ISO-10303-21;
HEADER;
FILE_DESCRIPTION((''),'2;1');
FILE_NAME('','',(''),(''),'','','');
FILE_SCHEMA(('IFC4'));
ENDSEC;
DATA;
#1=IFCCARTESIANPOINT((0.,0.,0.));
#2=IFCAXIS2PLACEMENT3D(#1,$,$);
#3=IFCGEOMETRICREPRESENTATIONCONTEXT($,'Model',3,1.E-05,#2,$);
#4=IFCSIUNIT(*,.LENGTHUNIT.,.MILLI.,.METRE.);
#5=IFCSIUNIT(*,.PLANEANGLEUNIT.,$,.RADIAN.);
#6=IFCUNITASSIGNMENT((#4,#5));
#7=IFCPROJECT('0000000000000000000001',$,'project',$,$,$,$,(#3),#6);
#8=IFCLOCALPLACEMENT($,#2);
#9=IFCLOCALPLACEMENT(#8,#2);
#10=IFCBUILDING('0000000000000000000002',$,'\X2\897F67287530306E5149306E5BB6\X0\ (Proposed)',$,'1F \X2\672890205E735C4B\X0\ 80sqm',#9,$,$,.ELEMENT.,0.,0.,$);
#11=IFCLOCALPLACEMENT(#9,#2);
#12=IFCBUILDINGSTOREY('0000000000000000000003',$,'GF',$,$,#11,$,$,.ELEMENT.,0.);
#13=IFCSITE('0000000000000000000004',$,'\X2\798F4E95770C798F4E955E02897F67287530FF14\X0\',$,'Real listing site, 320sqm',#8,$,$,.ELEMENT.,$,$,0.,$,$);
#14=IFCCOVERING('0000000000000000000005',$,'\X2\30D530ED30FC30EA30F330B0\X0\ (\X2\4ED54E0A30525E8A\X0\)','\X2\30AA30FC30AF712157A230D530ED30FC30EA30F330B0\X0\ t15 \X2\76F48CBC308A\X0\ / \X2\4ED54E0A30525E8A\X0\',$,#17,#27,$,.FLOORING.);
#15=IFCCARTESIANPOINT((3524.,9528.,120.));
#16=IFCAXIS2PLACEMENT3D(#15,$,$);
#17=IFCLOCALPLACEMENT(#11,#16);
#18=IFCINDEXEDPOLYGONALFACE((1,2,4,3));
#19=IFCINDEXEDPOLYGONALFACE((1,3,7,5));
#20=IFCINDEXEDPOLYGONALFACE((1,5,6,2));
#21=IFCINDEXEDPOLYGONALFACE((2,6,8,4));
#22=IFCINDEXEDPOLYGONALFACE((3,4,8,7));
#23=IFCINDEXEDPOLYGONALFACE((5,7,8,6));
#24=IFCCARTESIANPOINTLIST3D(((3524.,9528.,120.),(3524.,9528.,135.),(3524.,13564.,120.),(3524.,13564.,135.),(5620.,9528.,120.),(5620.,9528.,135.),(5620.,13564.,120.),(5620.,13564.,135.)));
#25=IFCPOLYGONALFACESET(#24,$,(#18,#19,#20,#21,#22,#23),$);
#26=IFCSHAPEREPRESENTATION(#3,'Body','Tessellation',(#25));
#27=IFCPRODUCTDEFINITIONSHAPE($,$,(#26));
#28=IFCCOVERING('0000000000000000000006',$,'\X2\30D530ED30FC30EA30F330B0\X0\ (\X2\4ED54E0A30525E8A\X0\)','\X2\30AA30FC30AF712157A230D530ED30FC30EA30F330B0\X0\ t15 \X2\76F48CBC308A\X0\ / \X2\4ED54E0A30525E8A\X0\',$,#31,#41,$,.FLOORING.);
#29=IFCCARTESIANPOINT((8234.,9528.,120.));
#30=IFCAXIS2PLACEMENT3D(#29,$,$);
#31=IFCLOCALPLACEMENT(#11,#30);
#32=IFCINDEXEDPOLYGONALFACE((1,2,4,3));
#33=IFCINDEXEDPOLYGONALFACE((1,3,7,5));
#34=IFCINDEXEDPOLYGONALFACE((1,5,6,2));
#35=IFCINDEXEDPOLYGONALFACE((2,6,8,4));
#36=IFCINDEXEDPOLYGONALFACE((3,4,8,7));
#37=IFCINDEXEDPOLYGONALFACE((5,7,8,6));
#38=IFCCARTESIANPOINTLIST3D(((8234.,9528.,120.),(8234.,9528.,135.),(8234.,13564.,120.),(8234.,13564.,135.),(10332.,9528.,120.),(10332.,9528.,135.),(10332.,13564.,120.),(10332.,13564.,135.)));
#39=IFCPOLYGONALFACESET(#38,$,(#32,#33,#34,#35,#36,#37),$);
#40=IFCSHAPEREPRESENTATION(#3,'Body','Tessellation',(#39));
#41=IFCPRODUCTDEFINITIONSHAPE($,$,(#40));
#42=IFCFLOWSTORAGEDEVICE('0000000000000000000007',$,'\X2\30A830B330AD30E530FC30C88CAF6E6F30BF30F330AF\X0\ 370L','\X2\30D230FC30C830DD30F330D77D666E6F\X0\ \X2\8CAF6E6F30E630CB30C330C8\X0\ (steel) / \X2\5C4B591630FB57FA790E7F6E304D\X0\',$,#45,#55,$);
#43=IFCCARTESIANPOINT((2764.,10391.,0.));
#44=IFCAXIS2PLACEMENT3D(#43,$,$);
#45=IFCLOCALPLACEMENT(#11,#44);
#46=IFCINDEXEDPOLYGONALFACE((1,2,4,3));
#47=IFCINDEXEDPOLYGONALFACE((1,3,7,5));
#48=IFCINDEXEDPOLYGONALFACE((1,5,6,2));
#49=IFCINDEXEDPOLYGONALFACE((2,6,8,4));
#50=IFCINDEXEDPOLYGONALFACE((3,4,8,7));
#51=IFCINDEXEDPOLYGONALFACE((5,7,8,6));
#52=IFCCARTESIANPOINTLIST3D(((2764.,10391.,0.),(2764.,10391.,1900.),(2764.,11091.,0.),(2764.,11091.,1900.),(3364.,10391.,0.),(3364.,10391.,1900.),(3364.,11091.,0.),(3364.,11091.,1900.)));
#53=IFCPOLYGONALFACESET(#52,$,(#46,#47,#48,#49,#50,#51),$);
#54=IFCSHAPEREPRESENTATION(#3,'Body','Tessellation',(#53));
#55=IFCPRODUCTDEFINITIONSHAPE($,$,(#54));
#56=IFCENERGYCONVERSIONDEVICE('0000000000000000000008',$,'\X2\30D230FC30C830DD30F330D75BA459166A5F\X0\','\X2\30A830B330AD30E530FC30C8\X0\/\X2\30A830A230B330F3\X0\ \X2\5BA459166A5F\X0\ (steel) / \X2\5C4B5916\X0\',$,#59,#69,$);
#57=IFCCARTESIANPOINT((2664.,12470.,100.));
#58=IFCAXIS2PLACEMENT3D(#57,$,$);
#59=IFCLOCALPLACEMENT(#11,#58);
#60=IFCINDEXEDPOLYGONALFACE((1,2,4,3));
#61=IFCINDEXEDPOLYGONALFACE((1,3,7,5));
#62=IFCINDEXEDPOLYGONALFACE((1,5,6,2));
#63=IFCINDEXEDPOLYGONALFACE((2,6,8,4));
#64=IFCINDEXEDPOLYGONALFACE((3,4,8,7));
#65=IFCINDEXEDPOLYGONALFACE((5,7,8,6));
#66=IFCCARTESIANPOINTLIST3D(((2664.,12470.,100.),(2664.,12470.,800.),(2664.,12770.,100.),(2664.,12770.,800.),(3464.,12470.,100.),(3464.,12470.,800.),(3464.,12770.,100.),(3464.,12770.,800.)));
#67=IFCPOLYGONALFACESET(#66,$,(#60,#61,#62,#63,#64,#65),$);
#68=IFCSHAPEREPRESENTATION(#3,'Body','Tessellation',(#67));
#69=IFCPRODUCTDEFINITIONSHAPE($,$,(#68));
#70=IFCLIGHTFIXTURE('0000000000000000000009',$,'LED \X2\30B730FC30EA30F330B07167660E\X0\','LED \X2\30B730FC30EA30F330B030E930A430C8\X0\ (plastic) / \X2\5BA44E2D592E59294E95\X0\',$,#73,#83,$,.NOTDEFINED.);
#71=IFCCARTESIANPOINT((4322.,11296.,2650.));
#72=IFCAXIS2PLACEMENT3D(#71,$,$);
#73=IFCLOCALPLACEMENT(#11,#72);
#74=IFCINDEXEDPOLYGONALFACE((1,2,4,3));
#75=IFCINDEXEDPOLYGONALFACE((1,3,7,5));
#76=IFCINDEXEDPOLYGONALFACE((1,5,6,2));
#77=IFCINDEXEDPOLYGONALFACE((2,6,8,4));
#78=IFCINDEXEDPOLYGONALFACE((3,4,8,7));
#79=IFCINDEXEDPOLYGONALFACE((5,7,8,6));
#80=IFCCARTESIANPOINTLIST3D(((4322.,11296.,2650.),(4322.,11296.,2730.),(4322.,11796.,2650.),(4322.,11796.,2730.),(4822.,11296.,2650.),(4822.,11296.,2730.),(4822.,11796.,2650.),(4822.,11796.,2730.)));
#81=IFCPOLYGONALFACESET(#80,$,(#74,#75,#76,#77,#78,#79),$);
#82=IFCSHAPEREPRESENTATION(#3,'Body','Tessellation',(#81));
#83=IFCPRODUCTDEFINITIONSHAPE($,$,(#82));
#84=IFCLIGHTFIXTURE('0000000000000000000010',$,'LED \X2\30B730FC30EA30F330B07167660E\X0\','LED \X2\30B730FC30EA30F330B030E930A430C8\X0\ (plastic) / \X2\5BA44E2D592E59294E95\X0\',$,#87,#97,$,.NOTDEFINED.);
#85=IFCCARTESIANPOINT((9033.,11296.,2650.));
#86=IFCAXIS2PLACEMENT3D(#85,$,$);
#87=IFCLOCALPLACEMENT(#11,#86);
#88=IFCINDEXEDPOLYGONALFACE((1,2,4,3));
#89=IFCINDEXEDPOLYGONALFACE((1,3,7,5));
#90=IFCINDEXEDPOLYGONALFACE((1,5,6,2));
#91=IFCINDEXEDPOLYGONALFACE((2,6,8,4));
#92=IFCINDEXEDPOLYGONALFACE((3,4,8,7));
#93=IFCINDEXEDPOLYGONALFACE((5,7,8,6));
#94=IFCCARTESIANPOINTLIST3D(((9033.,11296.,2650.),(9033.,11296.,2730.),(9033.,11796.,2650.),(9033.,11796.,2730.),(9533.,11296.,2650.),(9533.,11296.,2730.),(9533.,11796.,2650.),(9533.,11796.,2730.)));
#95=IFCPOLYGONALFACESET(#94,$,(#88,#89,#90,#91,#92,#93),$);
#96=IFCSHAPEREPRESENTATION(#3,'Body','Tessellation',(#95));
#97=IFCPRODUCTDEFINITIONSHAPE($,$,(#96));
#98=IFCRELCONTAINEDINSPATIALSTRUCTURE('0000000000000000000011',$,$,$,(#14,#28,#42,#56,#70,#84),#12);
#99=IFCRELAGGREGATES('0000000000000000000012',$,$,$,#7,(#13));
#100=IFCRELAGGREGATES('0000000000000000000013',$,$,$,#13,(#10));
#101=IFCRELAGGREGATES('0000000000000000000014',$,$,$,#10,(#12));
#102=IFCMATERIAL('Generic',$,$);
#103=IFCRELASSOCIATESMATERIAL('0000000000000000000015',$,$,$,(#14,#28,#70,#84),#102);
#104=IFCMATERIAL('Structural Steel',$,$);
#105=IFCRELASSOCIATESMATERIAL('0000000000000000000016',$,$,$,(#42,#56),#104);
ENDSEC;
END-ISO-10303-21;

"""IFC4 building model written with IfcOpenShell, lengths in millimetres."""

from ifc_helpers import new_model, si_unit, frame, frame_2d, origin, place, context, project, spatial, rectangle, extrude, material, element, save


model = new_model("IFC4")

# Units and contexts
model_context = context("Model", 3, precision=1e-05, world=origin())
ifc_project = project(units=[si_unit("LENGTHUNIT", "METRE", prefix="MILLI"), si_unit("PLANEANGLEUNIT", "RADIAN")], contexts=[model_context])

# Site, building, storey
site_placement = place(None, origin())
site = spatial("IfcSite", under=ifc_project, at=site_placement, Name="福井県福井市西木田４", ObjectType="Real listing site, 320sqm", CompositionType="ELEMENT", RefElevation=0.0)
building_placement = place(site_placement, origin())
building = spatial("IfcBuilding", under=site, at=building_placement, Name="西木田の光の家 (Proposed)", ObjectType="1F 木造平屋 80sqm", CompositionType="ELEMENT", ElevationOfRefHeight=0.0, ElevationOfTerrain=0.0)
storey_placement = place(building_placement, origin())
storey = spatial("IfcBuildingStorey", under=building, at=storey_placement, Name="GF", CompositionType="ELEMENT", Elevation=0.0)

# Shared definitions
ifc_material_1 = material(Name="Structural Steel")

# Coverings
ifc_material_2 = material(Name="Generic")
covering_1_placement = place(storey_placement, frame((3524.0, 9528.0, 120.0)))
element("IfcCovering", 1, at=covering_1_placement, inside=storey, material=ifc_material_2, Name="フローリング (仕上げ床)", Description="オーク無垢フローリング t15 直貼り / 仕上げ床", PredefinedType="FLOORING", context=model_context, shape_type="SweptSolid", body=[
    extrude(rectangle(XDim=2096.0, YDim=4036.0, at=frame_2d((1048.0, 2018.0))), frame((3524.0, 9528.0, 120.0)), (0.0, 0.0, 1.0), 15.0),
])
covering_2_placement = place(storey_placement, frame((8234.0, 9528.0, 120.0)))
element("IfcCovering", 2, at=covering_2_placement, inside=storey, material=ifc_material_2, Name="フローリング (仕上げ床)", Description="オーク無垢フローリング t15 直貼り / 仕上げ床", PredefinedType="FLOORING", context=model_context, shape_type="SweptSolid", body=[
    extrude(rectangle(XDim=2098.0, YDim=4036.0, at=frame_2d((1049.0, 2018.0))), frame((8234.0, 9528.0, 120.0)), (0.0, 0.0, 1.0), 15.0),
])

# Flow storage device
flow_storage_device_placement = place(storey_placement, frame((2764.0, 10391.0, 0.0)))
element("IfcFlowStorageDevice", 3, at=flow_storage_device_placement, inside=storey, material=ifc_material_1, Name="エコキュート貯湯タンク 370L", Description="ヒートポンプ給湯 貯湯ユニット (steel) / 屋外・基礎置き", context=model_context, shape_type="SweptSolid", body=[
    extrude(rectangle(XDim=600.0, YDim=700.0, at=frame_2d((300.0, 350.0))), frame((2764.0, 10391.0, 0.0)), (0.0, 0.0, 1.0), 1900.0),
])

# Energy conversion device
energy_conversion_device_placement = place(storey_placement, frame((2664.0, 12470.0, 100.0)))
element("IfcEnergyConversionDevice", 4, at=energy_conversion_device_placement, inside=storey, material=ifc_material_1, Name="ヒートポンプ室外機", Description="エコキュート/エアコン 室外機 (steel) / 屋外", context=model_context, shape_type="SweptSolid", body=[
    extrude(rectangle(XDim=800.0, YDim=300.0, at=frame_2d((400.0, 150.0))), frame((2664.0, 12470.0, 100.0)), (0.0, 0.0, 1.0), 700.0),
])

# Light fixtures
light_fixture_1_placement = place(storey_placement, frame((4322.0, 11296.0, 2650.0)))
element("IfcLightFixture", 5, at=light_fixture_1_placement, inside=storey, material=ifc_material_2, Name="LED シーリング照明", Description="LED シーリングライト (plastic) / 室中央天井", PredefinedType="NOTDEFINED", context=model_context, shape_type="SweptSolid", body=[
    extrude(rectangle(XDim=500.0, YDim=500.0, at=frame_2d((250.0, 250.0))), frame((4322.0, 11296.0, 2650.0)), (0.0, 0.0, 1.0), 80.0),
])
light_fixture_2_placement = place(storey_placement, frame((9033.0, 11296.0, 2650.0)))
element("IfcLightFixture", 6, at=light_fixture_2_placement, inside=storey, material=ifc_material_2, Name="LED シーリング照明", Description="LED シーリングライト (plastic) / 室中央天井", PredefinedType="NOTDEFINED", context=model_context, shape_type="SweptSolid", body=[
    extrude(rectangle(XDim=500.0, YDim=500.0, at=frame_2d((250.0, 250.0))), frame((9033.0, 11296.0, 2650.0)), (0.0, 0.0, 1.0), 80.0),
])

save(model, "model.ifc")
